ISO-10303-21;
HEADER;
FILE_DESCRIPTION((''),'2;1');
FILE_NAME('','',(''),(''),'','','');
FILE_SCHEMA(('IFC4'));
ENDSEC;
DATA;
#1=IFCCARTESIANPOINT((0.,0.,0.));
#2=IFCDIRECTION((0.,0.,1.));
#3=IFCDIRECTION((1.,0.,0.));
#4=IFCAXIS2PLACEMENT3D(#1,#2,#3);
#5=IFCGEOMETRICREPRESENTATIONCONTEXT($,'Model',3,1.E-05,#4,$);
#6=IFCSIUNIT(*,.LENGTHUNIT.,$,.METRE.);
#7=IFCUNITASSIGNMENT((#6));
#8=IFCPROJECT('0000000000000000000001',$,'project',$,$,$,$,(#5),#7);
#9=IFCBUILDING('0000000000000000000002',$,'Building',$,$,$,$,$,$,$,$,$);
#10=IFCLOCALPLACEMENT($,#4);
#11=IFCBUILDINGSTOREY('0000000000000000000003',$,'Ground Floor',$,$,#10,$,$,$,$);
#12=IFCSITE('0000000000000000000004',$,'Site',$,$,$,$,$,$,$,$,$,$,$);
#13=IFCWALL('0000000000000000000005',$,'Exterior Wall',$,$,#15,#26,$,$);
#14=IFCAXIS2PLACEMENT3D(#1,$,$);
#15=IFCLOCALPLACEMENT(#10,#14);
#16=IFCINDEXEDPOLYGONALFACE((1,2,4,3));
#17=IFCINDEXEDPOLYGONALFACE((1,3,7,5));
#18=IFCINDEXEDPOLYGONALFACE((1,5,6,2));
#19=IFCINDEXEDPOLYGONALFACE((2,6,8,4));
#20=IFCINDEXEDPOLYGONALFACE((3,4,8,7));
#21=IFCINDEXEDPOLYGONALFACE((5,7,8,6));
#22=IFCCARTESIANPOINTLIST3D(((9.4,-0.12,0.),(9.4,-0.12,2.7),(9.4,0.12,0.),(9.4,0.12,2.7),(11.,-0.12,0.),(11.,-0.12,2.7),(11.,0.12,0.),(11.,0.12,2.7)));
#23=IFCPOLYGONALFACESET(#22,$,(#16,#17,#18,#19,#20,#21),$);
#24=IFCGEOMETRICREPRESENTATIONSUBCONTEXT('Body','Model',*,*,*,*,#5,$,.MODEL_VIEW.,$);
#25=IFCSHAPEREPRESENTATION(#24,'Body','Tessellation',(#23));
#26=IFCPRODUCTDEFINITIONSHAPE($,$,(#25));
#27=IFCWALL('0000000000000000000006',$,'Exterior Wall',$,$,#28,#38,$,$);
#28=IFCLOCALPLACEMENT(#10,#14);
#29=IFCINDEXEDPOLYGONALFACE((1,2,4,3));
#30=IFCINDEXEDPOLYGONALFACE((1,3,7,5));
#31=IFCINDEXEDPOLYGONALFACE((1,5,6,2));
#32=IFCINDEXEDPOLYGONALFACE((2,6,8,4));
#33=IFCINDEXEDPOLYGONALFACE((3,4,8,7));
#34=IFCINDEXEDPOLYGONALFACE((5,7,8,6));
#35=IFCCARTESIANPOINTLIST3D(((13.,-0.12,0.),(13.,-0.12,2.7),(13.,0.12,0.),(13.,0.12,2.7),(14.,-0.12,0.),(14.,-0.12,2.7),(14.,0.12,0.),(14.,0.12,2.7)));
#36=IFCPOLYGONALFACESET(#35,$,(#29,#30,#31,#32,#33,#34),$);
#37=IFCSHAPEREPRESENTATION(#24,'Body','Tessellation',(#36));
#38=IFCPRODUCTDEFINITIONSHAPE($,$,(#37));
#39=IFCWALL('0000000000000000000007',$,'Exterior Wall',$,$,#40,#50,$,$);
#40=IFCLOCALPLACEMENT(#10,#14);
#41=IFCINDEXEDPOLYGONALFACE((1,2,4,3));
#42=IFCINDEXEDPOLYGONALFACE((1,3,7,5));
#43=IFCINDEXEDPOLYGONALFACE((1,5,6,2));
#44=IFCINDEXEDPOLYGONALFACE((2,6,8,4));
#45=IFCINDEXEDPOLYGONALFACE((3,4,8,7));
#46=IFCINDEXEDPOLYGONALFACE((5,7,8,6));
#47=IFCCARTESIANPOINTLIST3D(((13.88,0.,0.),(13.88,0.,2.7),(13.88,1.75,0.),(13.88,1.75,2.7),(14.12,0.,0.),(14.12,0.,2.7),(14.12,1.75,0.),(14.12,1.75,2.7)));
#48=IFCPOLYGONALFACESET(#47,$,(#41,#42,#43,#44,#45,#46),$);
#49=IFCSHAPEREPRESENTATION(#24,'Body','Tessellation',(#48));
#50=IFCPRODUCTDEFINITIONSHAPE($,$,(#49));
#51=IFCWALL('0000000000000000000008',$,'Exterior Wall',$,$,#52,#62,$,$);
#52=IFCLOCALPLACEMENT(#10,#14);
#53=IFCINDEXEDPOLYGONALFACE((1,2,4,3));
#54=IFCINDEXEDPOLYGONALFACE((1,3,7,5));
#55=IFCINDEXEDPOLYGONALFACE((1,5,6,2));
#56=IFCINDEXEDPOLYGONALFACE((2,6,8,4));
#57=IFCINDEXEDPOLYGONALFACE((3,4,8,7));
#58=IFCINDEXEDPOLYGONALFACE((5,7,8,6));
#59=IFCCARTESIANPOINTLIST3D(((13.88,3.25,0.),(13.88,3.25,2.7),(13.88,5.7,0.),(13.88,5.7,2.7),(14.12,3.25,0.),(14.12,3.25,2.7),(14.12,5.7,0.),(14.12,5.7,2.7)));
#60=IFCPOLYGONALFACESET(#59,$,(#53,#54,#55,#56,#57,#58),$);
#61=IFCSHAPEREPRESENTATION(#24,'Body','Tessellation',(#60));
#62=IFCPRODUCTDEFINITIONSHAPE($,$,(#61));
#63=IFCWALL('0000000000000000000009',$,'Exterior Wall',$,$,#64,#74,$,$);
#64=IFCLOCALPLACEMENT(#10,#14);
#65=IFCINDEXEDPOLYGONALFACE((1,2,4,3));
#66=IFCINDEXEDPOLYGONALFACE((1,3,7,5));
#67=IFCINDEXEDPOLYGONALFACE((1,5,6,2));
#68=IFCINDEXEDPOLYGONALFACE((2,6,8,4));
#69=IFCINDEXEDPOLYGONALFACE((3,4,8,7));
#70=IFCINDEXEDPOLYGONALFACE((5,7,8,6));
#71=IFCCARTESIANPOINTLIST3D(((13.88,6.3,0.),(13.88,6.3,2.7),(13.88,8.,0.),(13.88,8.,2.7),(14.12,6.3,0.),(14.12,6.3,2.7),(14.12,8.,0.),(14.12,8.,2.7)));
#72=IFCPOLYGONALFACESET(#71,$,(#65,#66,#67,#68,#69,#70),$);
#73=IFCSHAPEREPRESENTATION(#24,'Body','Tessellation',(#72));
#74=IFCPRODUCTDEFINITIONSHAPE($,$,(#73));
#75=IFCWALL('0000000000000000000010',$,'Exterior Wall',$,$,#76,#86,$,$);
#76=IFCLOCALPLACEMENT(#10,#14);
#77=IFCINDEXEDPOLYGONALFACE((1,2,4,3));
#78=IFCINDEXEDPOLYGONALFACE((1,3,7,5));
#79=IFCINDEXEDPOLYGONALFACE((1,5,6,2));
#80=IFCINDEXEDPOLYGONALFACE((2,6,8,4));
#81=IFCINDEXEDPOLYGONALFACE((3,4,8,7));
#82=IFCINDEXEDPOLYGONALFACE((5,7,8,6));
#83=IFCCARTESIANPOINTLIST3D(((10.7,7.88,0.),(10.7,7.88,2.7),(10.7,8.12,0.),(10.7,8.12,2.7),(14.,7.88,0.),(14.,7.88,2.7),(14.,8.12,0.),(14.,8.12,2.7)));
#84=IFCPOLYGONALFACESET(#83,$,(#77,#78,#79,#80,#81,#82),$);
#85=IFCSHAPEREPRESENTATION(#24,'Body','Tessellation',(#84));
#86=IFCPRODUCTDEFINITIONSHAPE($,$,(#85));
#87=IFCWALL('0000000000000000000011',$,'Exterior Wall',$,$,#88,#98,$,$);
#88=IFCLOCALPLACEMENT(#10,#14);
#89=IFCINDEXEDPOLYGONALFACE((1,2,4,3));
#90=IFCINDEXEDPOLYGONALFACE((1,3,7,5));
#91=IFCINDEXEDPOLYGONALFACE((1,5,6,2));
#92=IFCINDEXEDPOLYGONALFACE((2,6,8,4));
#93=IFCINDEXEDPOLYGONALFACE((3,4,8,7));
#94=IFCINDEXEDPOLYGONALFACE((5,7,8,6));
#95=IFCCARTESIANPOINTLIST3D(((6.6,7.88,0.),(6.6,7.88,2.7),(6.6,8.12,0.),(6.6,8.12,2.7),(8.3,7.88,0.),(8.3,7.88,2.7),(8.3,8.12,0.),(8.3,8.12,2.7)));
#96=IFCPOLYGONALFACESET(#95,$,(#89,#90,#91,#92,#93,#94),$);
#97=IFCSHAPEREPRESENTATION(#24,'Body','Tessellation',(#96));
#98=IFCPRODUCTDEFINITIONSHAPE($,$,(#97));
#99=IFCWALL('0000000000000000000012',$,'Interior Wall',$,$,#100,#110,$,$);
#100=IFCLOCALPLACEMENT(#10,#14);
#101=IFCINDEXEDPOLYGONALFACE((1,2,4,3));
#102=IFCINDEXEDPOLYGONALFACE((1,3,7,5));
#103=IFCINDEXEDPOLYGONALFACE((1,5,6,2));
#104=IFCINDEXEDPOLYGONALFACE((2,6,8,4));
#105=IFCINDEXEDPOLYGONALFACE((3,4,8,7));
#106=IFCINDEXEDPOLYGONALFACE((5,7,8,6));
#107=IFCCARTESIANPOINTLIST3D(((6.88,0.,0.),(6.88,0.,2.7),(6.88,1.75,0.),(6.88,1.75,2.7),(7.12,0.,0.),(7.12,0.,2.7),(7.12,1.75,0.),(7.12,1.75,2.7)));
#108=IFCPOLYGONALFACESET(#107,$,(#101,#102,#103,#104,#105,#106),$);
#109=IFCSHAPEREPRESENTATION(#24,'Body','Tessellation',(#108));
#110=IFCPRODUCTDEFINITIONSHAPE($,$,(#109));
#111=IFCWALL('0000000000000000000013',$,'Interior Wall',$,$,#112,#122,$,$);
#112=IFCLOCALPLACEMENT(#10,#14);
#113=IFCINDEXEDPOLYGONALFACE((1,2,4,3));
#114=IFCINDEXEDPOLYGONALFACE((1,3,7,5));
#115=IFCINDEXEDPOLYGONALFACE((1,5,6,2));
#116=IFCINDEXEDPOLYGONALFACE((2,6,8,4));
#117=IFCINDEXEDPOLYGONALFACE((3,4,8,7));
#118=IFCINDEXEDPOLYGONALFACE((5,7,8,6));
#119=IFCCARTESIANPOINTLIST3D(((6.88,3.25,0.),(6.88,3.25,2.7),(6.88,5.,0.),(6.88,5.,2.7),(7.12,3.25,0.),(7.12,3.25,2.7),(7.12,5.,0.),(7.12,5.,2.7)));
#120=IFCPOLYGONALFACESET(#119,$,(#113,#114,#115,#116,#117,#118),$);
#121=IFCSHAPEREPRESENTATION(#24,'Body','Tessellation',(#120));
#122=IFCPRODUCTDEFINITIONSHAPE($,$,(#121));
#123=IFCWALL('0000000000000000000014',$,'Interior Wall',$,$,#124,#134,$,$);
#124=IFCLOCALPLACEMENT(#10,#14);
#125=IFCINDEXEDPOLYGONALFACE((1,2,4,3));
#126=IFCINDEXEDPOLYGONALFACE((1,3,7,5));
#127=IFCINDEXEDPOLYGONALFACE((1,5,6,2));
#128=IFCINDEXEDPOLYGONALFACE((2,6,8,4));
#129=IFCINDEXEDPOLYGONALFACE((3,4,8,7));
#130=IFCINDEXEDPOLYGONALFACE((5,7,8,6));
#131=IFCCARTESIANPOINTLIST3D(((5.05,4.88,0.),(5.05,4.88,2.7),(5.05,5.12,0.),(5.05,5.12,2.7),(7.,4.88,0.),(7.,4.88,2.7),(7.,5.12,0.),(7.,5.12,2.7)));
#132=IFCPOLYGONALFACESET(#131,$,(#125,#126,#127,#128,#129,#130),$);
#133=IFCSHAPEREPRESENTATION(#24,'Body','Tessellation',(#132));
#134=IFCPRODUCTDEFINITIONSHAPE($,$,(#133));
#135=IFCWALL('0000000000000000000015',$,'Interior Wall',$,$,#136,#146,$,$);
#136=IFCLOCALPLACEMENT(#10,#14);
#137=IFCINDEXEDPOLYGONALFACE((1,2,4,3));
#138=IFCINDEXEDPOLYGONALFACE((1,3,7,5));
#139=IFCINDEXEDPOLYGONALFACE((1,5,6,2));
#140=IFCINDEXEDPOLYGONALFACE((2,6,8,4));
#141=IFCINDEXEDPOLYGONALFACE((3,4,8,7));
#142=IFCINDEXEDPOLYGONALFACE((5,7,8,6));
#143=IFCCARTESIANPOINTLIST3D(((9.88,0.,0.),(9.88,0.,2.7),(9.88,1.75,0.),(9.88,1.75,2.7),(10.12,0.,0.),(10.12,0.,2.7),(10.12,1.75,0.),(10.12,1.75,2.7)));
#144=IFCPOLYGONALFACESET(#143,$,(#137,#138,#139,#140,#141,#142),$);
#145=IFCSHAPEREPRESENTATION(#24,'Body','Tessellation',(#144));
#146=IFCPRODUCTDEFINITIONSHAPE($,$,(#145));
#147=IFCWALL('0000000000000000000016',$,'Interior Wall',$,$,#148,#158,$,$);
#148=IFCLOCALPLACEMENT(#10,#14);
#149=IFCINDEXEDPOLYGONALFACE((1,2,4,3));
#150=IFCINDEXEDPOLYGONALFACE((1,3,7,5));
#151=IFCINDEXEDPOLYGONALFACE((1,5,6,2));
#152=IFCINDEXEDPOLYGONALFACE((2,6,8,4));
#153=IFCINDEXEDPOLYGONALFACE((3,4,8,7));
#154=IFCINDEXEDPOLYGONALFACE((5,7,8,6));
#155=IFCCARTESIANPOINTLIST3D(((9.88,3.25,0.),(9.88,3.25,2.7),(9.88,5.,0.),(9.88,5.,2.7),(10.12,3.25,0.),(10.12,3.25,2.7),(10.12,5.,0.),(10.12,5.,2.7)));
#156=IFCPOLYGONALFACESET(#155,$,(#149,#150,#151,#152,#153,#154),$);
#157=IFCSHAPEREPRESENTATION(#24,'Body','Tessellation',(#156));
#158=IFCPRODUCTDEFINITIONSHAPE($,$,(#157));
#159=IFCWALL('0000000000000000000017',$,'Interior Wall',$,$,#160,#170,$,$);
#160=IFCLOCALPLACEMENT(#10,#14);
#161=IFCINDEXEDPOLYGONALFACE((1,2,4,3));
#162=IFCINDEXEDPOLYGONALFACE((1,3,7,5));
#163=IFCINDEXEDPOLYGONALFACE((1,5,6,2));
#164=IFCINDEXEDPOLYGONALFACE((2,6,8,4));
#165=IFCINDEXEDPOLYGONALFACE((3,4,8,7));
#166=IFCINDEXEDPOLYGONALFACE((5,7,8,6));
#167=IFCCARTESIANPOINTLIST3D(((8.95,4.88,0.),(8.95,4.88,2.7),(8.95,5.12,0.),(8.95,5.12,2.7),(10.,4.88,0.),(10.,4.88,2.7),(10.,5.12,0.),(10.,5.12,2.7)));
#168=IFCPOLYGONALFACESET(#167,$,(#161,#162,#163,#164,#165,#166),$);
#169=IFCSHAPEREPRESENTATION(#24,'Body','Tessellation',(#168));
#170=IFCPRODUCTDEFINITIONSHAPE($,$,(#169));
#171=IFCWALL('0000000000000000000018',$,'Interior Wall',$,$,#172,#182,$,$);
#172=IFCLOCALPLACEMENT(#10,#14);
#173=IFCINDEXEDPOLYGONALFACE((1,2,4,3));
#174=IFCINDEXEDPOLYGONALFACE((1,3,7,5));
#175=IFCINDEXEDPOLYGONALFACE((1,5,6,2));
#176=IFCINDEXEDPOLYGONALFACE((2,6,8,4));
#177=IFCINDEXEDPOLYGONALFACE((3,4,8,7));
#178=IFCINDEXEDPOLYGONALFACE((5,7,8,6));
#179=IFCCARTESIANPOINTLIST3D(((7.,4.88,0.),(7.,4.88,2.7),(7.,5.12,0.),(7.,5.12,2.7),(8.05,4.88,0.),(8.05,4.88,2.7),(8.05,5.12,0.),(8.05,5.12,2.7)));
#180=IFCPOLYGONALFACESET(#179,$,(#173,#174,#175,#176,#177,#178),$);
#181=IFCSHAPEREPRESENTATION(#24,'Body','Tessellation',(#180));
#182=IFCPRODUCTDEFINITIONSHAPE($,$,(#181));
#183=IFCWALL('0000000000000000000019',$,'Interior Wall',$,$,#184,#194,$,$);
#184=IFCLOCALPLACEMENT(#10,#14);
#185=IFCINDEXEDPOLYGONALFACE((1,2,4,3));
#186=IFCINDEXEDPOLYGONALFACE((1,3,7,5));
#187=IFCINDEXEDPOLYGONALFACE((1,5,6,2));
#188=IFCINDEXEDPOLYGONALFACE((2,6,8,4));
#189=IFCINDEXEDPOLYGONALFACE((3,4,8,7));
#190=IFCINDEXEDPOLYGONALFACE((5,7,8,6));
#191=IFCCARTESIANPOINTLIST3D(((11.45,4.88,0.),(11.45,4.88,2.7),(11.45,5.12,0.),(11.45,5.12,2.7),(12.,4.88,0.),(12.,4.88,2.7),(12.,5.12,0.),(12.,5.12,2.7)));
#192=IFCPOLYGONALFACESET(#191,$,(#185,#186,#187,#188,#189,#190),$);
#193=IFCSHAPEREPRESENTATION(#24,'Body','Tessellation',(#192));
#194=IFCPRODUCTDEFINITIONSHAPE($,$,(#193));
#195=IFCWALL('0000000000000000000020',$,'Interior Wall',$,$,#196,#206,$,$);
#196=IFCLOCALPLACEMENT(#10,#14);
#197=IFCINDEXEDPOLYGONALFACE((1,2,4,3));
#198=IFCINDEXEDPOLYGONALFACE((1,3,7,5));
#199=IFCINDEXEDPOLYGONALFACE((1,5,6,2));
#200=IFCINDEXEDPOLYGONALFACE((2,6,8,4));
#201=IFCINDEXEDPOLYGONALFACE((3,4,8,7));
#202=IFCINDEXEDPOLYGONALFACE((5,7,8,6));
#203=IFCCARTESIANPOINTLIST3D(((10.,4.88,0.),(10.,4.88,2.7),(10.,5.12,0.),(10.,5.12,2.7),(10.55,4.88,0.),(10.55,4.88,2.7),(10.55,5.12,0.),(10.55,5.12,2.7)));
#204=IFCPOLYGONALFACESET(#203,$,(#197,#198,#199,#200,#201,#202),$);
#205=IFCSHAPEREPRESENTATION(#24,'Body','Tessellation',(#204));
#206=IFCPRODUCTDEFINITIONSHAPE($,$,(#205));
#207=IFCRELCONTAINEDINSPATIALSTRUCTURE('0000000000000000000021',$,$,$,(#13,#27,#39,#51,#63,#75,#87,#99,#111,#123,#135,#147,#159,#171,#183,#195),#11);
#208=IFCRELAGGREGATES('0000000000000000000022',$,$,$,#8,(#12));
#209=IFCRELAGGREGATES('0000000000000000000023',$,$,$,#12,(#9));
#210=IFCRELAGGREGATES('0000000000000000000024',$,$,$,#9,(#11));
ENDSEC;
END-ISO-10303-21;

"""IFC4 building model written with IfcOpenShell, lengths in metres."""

from ifc_helpers import new_model, si_unit, frame, origin_with_axes, place, context, subcontext, project, spatial, indexed_curve, outline, extrude, element, save


model = new_model("IFC4")

# Units and contexts
model_context = context("Model", 3, precision=1e-05, world=origin_with_axes())
body_context = subcontext(model_context, "Body", "Model", "MODEL_VIEW")
ifc_project = project(units=[si_unit("LENGTHUNIT", "METRE")], contexts=[model_context])

# Site, building, storey
site = spatial("IfcSite", under=ifc_project, Name="Site")
building = spatial("IfcBuilding", under=site, Name="Building")
storey_placement = place(None, origin_with_axes())
storey = spatial("IfcBuildingStorey", under=building, at=storey_placement, Name="Ground Floor")

# Walls
wall_1_placement = place(storey_placement, frame((9.4, 0.0, 0.0), z_axis=(0.0, 0.0, 1.0), x_axis=(1.0, 0.0, 0.0)))
element("IfcWall", 1, at=wall_1_placement, inside=storey, Name="Exterior Wall", context=body_context, shape_type="SweptSolid", body=[
    extrude(outline(indexed_curve([(0.0, 0.0), (0.0, 0.24), (1.6, 0.24), (1.6, 0.0), (0.0, 0.0)], self_intersect=False)), frame((0.0, -0.12, 0.0), z_axis=(0.0, 0.0, 1.0), x_axis=(1.0, 0.0, 0.0)), (0.0, 0.0, 1.0), 2.7),
])
wall_2_placement = place(storey_placement, frame((13.0, 0.0, 0.0), z_axis=(0.0, 0.0, 1.0), x_axis=(1.0, 0.0, 0.0)))
element("IfcWall", 2, at=wall_2_placement, inside=storey, Name="Exterior Wall", context=body_context, shape_type="SweptSolid", body=[
    extrude(outline(indexed_curve([(0.0, 0.0), (0.0, 0.24), (1.0, 0.24), (1.0, 0.0), (0.0, 0.0)], self_intersect=False)), frame((0.0, -0.12, 0.0), z_axis=(0.0, 0.0, 1.0), x_axis=(1.0, 0.0, 0.0)), (0.0, 0.0, 1.0), 2.7),
])
wall_3_placement = place(storey_placement, frame((14.0, 0.0, 0.0), z_axis=(0.0, 0.0, 1.0), x_axis=(0.0, 1.0, 0.0)))
element("IfcWall", 3, at=wall_3_placement, inside=storey, Name="Exterior Wall", context=body_context, shape_type="SweptSolid", body=[
    extrude(outline(indexed_curve([(0.0, 0.0), (0.0, 0.24), (1.75, 0.24), (1.75, 0.0), (0.0, 0.0)], self_intersect=False)), frame((0.0, -0.12, 0.0), z_axis=(0.0, 0.0, 1.0), x_axis=(1.0, 0.0, 0.0)), (0.0, 0.0, 1.0), 2.7),
])
wall_4_placement = place(storey_placement, frame((14.0, 3.25, 0.0), z_axis=(0.0, 0.0, 1.0), x_axis=(0.0, 1.0, 0.0)))
element("IfcWall", 4, at=wall_4_placement, inside=storey, Name="Exterior Wall", context=body_context, shape_type="SweptSolid", body=[
    extrude(outline(indexed_curve([(0.0, 0.0), (0.0, 0.24), (2.45, 0.24), (2.45, 0.0), (0.0, 0.0)], self_intersect=False)), frame((0.0, -0.12, 0.0), z_axis=(0.0, 0.0, 1.0), x_axis=(1.0, 0.0, 0.0)), (0.0, 0.0, 1.0), 2.7),
])
wall_5_placement = place(storey_placement, frame((14.0, 6.3, 0.0), z_axis=(0.0, 0.0, 1.0), x_axis=(0.0, 1.0, 0.0)))
element("IfcWall", 5, at=wall_5_placement, inside=storey, Name="Exterior Wall", context=body_context, shape_type="SweptSolid", body=[
    extrude(outline(indexed_curve([(0.0, 0.0), (0.0, 0.24), (1.7, 0.24), (1.7, 0.0), (0.0, 0.0)], self_intersect=False)), frame((0.0, -0.12, 0.0), z_axis=(0.0, 0.0, 1.0), x_axis=(1.0, 0.0, 0.0)), (0.0, 0.0, 1.0), 2.7),
])
wall_6_placement = place(storey_placement, frame((14.0, 8.0, 0.0), z_axis=(0.0, 0.0, 1.0), x_axis=(-1.0, 0.0, 0.0)))
element("IfcWall", 6, at=wall_6_placement, inside=storey, Name="Exterior Wall", context=body_context, shape_type="SweptSolid", body=[
    extrude(outline(indexed_curve([(0.0, 0.0), (0.0, 0.24), (3.3, 0.24), (3.3, 0.0), (0.0, 0.0)], self_intersect=False)), frame((0.0, -0.12, 0.0), z_axis=(0.0, 0.0, 1.0), x_axis=(1.0, 0.0, 0.0)), (0.0, 0.0, 1.0), 2.7),
])
wall_7_placement = place(storey_placement, frame((8.3, 8.0, 0.0), z_axis=(0.0, 0.0, 1.0), x_axis=(-1.0, 0.0, 0.0)))
element("IfcWall", 7, at=wall_7_placement, inside=storey, Name="Exterior Wall", context=body_context, shape_type="SweptSolid", body=[
    extrude(outline(indexed_curve([(0.0, 0.0), (0.0, 0.24), (1.7, 0.24), (1.7, 0.0), (0.0, 0.0)], self_intersect=False)), frame((0.0, -0.12, 0.0), z_axis=(0.0, 0.0, 1.0), x_axis=(1.0, 0.0, 0.0)), (0.0, 0.0, 1.0), 2.7),
])
for number, where, z_axis, x_axis, name in (
    (8, (7.0, 0.0, 0.0), (0.0, 0.0, 1.0), (0.0, 1.0, 0.0), "Interior Wall"),
    (9, (7.0, 3.25, 0.0), (0.0, 0.0, 1.0), (0.0, 1.0, 0.0), "Interior Wall"),
):
    element("IfcWall", number, at=place(storey_placement, frame(where, z_axis=z_axis, x_axis=x_axis)), inside=storey, Name=name, context=body_context, shape_type="SweptSolid", body=[
        extrude(outline(indexed_curve([(0.0, 0.0), (0.0, 0.24), (1.75, 0.24), (1.75, 0.0), (0.0, 0.0)], self_intersect=False)), frame((0.0, -0.12, 0.0), z_axis=(0.0, 0.0, 1.0), x_axis=(1.0, 0.0, 0.0)), (0.0, 0.0, 1.0), 2.7),
    ])
wall_8_placement = place(storey_placement, frame((7.0, 5.0, 0.0), z_axis=(0.0, 0.0, 1.0), x_axis=(-1.0, 0.0, 0.0)))
element("IfcWall", 10, at=wall_8_placement, inside=storey, Name="Interior Wall", context=body_context, shape_type="SweptSolid", body=[
    extrude(outline(indexed_curve([(0.0, 0.0), (0.0, 0.24), (1.95, 0.24), (1.95, 0.0), (0.0, 0.0)], self_intersect=False)), frame((0.0, -0.12, 0.0), z_axis=(0.0, 0.0, 1.0), x_axis=(1.0, 0.0, 0.0)), (0.0, 0.0, 1.0), 2.7),
])
for number, where, z_axis, x_axis, name in (
    (11, (10.0, 0.0, 0.0), (0.0, 0.0, 1.0), (0.0, 1.0, 0.0), "Interior Wall"),
    (12, (10.0, 3.25, 0.0), (0.0, 0.0, 1.0), (0.0, 1.0, 0.0), "Interior Wall"),
):
    element("IfcWall", number, at=place(storey_placement, frame(where, z_axis=z_axis, x_axis=x_axis)), inside=storey, Name=name, context=body_context, shape_type="SweptSolid", body=[
        extrude(outline(indexed_curve([(0.0, 0.0), (0.0, 0.24), (1.75, 0.24), (1.75, 0.0), (0.0, 0.0)], self_intersect=False)), frame((0.0, -0.12, 0.0), z_axis=(0.0, 0.0, 1.0), x_axis=(1.0, 0.0, 0.0)), (0.0, 0.0, 1.0), 2.7),
    ])
for number, where, z_axis, x_axis, name in (
    (13, (10.0, 5.0, 0.0), (0.0, 0.0, 1.0), (-1.0, 0.0, 0.0), "Interior Wall"),
    (14, (8.05, 5.0, 0.0), (0.0, 0.0, 1.0), (-1.0, 0.0, 0.0), "Interior Wall"),
):
    element("IfcWall", number, at=place(storey_placement, frame(where, z_axis=z_axis, x_axis=x_axis)), inside=storey, Name=name, context=body_context, shape_type="SweptSolid", body=[
        extrude(outline(indexed_curve([(0.0, 0.0), (0.0, 0.24), (1.05, 0.24), (1.05, 0.0), (0.0, 0.0)], self_intersect=False)), frame((0.0, -0.12, 0.0), z_axis=(0.0, 0.0, 1.0), x_axis=(1.0, 0.0, 0.0)), (0.0, 0.0, 1.0), 2.7),
    ])
for number, where, z_axis, x_axis, name in (
    (15, (12.0, 5.0, 0.0), (0.0, 0.0, 1.0), (-1.0, 0.0, 0.0), "Interior Wall"),
    (16, (10.55, 5.0, 0.0), (0.0, 0.0, 1.0), (-1.0, 0.0, 0.0), "Interior Wall"),
):
    element("IfcWall", number, at=place(storey_placement, frame(where, z_axis=z_axis, x_axis=x_axis)), inside=storey, Name=name, context=body_context, shape_type="SweptSolid", body=[
        extrude(outline(indexed_curve([(0.0, 0.0), (0.0, 0.24), (0.55, 0.24), (0.55, 0.0), (0.0, 0.0)], self_intersect=False)), frame((0.0, -0.12, 0.0), z_axis=(0.0, 0.0, 1.0), x_axis=(1.0, 0.0, 0.0)), (0.0, 0.0, 1.0), 2.7),
    ])

save(model, "model.ifc")
